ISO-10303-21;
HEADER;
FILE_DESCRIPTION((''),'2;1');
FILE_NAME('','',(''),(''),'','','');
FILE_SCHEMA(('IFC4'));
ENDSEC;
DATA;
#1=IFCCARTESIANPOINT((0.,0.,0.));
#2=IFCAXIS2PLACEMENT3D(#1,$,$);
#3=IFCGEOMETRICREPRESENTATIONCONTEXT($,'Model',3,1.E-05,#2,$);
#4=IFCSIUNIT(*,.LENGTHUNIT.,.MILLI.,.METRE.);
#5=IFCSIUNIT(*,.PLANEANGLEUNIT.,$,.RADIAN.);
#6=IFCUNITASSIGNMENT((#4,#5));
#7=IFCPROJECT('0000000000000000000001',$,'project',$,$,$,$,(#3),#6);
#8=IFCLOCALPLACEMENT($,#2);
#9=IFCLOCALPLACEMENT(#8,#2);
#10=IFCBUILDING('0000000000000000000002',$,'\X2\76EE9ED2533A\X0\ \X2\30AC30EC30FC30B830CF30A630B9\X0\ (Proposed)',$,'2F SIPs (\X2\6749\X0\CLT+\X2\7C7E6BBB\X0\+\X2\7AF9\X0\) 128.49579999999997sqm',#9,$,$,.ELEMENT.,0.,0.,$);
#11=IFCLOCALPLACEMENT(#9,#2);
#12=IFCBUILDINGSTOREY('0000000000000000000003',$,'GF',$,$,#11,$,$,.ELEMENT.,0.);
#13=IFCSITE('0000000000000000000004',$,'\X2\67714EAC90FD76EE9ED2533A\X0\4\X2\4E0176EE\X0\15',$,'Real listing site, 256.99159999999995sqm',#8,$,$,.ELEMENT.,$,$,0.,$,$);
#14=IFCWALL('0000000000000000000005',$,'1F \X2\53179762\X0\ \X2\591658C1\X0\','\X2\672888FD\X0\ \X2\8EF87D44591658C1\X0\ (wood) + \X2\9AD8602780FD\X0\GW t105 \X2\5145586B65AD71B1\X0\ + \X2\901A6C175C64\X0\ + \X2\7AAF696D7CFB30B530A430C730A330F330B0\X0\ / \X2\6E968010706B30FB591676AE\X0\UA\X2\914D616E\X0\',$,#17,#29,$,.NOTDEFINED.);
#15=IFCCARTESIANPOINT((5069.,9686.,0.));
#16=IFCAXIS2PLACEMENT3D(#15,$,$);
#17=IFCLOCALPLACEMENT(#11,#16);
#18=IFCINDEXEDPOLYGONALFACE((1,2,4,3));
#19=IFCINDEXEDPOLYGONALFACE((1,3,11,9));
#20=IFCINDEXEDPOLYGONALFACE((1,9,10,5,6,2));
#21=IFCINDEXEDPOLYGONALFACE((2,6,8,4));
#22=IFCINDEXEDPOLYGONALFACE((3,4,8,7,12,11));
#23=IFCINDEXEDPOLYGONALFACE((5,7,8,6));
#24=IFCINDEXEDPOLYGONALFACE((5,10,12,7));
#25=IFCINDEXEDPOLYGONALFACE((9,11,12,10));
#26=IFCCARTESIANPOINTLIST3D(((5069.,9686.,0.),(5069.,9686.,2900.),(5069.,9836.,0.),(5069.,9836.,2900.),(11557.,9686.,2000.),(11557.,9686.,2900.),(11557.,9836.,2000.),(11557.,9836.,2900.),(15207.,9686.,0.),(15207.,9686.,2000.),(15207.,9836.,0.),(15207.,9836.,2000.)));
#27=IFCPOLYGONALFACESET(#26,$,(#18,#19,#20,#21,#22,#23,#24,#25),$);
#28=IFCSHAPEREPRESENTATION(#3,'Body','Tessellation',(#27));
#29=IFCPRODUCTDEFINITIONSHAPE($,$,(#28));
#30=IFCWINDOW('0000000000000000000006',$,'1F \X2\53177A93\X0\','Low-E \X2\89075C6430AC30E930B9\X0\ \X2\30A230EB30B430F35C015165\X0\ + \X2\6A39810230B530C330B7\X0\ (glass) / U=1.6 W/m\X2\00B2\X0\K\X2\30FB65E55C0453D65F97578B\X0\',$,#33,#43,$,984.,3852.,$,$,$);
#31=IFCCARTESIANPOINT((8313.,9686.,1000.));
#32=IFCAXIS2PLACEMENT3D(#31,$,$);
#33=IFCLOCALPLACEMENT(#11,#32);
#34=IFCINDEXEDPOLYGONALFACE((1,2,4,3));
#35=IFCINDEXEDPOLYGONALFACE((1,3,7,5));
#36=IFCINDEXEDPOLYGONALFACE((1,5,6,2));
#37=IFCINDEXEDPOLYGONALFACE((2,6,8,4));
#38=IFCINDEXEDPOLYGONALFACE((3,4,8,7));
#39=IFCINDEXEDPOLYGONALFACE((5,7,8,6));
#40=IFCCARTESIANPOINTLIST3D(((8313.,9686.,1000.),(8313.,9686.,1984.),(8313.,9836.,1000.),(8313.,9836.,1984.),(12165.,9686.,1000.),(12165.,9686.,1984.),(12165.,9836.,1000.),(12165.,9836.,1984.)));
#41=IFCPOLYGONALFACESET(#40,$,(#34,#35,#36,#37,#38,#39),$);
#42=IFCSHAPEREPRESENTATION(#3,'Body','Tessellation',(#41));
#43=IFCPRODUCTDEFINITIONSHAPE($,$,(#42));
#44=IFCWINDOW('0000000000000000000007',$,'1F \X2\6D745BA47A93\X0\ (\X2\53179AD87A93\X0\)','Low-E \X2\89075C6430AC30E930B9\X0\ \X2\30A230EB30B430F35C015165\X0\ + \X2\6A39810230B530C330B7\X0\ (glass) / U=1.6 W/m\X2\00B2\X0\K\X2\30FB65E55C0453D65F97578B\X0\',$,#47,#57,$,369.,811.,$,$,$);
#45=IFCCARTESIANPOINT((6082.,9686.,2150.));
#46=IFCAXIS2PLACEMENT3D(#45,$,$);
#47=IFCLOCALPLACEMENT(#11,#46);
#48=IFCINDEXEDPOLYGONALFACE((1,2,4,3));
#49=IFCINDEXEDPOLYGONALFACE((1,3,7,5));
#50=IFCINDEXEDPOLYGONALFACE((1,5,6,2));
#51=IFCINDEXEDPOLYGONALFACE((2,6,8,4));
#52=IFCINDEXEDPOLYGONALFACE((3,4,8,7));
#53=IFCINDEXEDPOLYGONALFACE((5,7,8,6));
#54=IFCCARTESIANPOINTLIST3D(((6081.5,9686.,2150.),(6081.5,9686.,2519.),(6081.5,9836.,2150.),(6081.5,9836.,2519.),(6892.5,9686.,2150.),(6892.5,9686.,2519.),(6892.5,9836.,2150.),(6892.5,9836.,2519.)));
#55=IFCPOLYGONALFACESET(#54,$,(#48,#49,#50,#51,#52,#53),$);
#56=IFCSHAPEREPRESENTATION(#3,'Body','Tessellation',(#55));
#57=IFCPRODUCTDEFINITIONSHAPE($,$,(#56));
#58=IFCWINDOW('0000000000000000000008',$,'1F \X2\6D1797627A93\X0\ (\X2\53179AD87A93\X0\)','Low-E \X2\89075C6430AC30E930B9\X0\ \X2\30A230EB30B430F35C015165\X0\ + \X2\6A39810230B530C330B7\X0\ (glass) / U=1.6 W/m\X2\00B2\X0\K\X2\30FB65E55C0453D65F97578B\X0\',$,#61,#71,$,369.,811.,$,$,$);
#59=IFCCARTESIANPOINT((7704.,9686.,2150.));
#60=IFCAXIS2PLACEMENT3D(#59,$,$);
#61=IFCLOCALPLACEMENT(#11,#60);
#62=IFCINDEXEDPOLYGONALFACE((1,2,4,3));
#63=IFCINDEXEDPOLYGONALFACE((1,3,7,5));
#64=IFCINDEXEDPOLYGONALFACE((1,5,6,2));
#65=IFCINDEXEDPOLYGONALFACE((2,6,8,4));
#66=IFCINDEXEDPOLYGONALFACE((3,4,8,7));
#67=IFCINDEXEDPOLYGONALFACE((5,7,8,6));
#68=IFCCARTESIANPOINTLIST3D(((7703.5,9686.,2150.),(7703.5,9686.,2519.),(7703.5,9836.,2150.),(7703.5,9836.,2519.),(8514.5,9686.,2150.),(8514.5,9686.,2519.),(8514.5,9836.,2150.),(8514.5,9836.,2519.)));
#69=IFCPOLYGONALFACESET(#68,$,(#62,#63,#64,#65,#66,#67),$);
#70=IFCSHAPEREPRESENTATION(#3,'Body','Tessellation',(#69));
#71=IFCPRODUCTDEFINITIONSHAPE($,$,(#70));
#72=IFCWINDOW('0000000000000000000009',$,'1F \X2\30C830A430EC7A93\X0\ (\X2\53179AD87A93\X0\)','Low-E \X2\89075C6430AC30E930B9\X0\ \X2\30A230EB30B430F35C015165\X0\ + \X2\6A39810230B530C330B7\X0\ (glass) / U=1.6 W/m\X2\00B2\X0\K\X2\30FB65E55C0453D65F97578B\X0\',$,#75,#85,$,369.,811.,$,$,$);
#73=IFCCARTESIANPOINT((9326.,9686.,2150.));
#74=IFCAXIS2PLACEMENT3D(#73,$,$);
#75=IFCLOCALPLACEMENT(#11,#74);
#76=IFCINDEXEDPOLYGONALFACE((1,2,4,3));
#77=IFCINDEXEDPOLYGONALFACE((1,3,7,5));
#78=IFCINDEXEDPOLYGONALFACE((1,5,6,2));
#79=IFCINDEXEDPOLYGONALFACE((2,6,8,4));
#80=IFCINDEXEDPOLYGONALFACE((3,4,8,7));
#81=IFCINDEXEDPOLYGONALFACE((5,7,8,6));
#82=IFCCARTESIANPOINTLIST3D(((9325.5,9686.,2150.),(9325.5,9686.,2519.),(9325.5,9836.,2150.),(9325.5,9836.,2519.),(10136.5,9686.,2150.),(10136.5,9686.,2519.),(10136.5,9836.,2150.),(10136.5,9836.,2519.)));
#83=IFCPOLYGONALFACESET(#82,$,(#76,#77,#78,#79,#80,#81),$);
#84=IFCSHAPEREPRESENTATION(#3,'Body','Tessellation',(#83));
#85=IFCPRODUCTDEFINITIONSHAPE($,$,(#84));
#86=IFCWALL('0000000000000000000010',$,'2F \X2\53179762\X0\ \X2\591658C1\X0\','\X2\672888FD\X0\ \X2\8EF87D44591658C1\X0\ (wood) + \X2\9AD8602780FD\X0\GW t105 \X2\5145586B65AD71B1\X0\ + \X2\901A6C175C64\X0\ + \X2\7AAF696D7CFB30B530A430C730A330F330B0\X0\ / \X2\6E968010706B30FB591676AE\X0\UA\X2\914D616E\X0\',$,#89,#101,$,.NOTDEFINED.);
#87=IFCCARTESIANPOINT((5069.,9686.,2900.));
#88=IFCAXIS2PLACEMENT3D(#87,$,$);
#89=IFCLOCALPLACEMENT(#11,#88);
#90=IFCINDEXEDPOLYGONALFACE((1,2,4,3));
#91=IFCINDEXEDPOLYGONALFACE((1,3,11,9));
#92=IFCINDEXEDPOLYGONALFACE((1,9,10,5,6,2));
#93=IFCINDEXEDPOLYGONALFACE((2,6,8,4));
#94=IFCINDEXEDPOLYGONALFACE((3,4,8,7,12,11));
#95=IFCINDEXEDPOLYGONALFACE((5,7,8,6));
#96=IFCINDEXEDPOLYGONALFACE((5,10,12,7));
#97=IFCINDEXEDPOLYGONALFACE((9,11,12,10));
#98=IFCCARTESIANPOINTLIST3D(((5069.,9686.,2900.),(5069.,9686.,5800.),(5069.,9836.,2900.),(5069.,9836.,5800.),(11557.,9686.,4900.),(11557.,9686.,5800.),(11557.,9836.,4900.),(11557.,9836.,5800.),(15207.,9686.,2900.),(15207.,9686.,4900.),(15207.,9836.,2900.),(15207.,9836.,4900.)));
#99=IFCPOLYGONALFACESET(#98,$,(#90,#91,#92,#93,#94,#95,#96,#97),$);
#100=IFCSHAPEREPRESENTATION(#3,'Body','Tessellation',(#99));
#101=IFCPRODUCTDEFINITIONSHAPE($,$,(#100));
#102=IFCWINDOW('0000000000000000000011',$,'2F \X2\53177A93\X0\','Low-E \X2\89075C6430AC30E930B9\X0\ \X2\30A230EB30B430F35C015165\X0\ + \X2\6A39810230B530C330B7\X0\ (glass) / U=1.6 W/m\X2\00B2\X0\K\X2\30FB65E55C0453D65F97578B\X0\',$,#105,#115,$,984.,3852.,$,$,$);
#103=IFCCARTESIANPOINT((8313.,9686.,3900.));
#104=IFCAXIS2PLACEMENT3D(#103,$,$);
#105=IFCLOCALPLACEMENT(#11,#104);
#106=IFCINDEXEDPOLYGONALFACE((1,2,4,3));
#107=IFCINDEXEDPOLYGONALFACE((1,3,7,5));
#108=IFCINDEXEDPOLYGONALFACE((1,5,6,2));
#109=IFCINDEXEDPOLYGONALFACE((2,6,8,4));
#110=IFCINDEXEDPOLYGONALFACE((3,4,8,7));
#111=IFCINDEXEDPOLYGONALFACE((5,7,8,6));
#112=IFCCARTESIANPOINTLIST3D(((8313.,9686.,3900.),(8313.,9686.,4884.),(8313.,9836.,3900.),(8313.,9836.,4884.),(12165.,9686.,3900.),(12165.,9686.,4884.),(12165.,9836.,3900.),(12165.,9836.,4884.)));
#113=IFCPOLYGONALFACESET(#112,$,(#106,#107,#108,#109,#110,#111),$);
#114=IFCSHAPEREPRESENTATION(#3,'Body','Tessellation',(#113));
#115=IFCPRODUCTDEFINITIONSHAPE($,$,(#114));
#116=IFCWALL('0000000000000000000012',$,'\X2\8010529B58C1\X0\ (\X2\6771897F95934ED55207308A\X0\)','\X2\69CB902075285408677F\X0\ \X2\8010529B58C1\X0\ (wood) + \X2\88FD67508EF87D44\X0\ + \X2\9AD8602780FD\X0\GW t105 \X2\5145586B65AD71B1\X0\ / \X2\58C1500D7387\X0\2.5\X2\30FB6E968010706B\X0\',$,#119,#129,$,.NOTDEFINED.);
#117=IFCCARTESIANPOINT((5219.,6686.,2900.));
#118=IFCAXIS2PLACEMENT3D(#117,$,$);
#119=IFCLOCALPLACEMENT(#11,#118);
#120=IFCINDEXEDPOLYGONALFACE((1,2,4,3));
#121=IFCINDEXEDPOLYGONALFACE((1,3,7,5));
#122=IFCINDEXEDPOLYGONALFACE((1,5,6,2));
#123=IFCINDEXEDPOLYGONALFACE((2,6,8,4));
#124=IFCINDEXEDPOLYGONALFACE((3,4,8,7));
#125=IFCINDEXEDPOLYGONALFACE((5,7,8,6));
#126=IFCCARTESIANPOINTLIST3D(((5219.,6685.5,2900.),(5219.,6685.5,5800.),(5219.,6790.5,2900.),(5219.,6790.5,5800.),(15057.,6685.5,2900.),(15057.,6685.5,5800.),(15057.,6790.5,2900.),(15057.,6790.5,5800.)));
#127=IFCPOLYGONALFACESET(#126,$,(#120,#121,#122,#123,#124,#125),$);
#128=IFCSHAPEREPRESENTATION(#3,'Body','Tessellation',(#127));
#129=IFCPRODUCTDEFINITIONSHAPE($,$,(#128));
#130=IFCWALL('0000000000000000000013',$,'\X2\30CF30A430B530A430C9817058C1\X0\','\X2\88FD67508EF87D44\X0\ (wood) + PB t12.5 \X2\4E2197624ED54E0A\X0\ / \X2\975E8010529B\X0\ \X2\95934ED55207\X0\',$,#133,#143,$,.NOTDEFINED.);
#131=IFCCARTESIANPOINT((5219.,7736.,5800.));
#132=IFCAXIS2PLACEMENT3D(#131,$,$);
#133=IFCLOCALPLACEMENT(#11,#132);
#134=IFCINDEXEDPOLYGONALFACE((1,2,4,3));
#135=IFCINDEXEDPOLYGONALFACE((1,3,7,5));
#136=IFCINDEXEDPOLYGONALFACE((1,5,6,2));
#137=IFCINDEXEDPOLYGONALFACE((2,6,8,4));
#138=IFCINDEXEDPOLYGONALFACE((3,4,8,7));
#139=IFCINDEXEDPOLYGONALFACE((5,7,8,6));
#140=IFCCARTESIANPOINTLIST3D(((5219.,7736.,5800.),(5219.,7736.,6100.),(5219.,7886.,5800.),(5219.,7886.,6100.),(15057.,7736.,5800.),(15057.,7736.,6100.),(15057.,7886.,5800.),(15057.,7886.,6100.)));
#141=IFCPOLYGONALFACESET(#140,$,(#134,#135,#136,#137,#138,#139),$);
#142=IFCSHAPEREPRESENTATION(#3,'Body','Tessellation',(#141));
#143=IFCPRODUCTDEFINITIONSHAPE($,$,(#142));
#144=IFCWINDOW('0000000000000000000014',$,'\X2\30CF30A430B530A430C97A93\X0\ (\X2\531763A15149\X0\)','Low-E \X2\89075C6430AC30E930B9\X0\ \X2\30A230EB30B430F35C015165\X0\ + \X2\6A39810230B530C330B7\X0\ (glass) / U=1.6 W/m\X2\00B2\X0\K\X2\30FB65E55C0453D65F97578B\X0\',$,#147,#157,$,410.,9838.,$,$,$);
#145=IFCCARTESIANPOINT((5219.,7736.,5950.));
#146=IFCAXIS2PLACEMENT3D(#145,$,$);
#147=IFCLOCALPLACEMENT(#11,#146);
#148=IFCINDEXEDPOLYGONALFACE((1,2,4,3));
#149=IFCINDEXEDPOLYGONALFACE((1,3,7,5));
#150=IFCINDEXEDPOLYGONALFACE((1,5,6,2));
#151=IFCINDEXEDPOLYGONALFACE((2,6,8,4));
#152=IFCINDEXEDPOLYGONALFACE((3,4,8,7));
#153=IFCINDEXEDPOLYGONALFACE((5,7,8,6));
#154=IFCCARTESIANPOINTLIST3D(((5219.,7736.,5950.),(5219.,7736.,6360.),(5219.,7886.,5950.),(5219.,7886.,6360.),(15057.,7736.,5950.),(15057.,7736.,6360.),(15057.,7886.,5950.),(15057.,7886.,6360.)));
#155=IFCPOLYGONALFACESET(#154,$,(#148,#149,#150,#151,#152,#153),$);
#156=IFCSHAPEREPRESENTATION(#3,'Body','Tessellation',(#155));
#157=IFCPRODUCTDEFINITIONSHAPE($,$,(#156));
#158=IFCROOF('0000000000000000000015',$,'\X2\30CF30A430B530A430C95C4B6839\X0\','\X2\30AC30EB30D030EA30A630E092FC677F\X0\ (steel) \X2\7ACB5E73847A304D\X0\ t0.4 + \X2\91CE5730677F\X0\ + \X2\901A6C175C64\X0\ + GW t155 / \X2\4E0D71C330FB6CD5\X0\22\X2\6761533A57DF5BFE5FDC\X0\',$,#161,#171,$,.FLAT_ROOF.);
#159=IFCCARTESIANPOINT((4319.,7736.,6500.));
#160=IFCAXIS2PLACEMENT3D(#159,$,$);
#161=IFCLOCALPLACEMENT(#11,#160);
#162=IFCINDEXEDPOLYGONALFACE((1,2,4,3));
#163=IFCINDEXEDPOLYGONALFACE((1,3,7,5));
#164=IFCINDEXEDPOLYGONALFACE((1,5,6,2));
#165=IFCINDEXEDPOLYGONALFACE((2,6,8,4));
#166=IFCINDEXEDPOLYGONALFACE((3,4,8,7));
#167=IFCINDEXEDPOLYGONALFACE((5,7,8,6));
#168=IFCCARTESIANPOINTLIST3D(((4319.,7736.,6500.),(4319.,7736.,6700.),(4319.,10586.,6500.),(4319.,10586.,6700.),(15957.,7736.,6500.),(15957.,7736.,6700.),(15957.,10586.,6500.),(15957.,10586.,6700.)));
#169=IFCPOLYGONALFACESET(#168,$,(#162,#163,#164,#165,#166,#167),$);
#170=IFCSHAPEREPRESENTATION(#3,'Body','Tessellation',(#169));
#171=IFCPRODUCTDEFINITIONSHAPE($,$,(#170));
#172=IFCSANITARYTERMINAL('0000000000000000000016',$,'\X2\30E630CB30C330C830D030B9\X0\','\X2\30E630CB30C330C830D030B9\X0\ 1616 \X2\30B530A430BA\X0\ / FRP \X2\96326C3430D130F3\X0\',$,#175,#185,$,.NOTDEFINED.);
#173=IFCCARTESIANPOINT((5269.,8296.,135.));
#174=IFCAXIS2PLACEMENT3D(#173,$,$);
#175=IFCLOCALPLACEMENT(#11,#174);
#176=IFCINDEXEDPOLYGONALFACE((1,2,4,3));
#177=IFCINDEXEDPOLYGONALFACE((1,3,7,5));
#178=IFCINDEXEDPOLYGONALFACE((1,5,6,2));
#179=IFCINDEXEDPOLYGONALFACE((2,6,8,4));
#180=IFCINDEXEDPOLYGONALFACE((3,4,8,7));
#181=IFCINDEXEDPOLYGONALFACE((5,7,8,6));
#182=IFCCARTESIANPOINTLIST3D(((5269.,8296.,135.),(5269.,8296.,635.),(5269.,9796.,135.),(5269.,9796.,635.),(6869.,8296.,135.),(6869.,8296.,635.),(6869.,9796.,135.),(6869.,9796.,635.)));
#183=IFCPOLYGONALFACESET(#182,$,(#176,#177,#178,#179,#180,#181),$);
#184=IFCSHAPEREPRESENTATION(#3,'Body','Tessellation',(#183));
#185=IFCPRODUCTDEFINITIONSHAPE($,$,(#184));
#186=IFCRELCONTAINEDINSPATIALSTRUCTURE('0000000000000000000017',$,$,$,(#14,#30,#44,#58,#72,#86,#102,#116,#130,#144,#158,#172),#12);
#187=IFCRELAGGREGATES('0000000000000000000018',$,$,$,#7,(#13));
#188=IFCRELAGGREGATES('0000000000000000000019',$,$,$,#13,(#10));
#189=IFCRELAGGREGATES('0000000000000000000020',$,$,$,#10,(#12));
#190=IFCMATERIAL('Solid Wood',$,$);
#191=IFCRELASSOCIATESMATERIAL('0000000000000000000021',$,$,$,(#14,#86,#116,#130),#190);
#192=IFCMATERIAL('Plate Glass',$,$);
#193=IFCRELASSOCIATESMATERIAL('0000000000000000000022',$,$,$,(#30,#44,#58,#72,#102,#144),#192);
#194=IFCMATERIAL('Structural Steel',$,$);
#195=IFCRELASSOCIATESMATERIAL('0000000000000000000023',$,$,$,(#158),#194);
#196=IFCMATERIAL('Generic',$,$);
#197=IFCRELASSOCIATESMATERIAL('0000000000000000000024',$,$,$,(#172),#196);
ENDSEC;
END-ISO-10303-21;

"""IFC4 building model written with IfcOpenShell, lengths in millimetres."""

from ifc_helpers import new_model, si_unit, frame, frame_2d, origin, place, context, project, spatial, rectangle, extrude, material, element, fill, save


model = new_model("IFC4")

# Units and contexts
model_context = context("Model", 3, precision=1e-05, world=origin())
ifc_project = project(units=[si_unit("LENGTHUNIT", "METRE", prefix="MILLI"), si_unit("PLANEANGLEUNIT", "RADIAN")], contexts=[model_context])

# Site, building, storey
site_placement = place(None, origin())
site = spatial("IfcSite", under=ifc_project, at=site_placement, Name="東京都目黒区4丁目15", ObjectType="Real listing site, 256.99159999999995sqm", CompositionType="ELEMENT", RefElevation=0.0)
building_placement = place(site_placement, origin())
building = spatial("IfcBuilding", under=site, at=building_placement, Name="目黒区 ガレージハウス (Proposed)", ObjectType="2F SIPs (杉CLT+籾殻+竹) 128.49579999999997sqm", CompositionType="ELEMENT", ElevationOfRefHeight=0.0, ElevationOfTerrain=0.0)
storey_placement = place(building_placement, origin())
storey = spatial("IfcBuildingStorey", under=building, at=storey_placement, Name="GF", CompositionType="ELEMENT", Elevation=0.0)

# Wall, openings, windows
ifc_material_1 = material(Name="Solid Wood")
wall_1_placement = place(storey_placement, frame((5069.0, 9686.0, 0.0)))
wall_1 = element("IfcWall", 1, at=wall_1_placement, inside=storey, material=ifc_material_1, Name="1F 北面 外壁", Description="木製 軸組外壁 (wood) + 高性能GW t105 充填断熱 + 通気層 + 窯業系サイディング / 準耐火・外皮UA配慮", PredefinedType="NOTDEFINED", context=model_context, shape_type="SweptSolid", body=[
    extrude(rectangle(XDim=10138.0, YDim=150.0, at=frame_2d((5069.0, 75.0))), frame((5069.0, 9686.0, 0.0)), (0.0, 0.0, 1.0), 2900.0),
])
opening_1_placement = place(storey_placement, frame((8313.0, 9686.0, 1000.0)))
opening_1 = element("IfcOpeningElement", 2, at=opening_1_placement, cuts=wall_1, PredefinedType="NOTDEFINED", context=model_context, shape_type="SweptSolid", body=[
    extrude(rectangle(XDim=3852.0, YDim=150.0, at=frame_2d((1926.0, 75.0))), frame((8313.0, 9686.0, 1000.0)), (0.0, 0.0, 1.0), 984.0),
])
opening_2_placement = place(storey_placement, frame((6082.0, 9686.0, 2150.0)))
opening_2 = element("IfcOpeningElement", 3, at=opening_2_placement, cuts=wall_1, PredefinedType="NOTDEFINED", context=model_context, shape_type="SweptSolid", body=[
    extrude(rectangle(XDim=811.0, YDim=150.0, at=frame_2d((405.0, 75.0))), frame((6082.0, 9686.0, 2150.0)), (0.0, 0.0, 1.0), 369.0),
])
opening_3_placement = place(storey_placement, frame((7704.0, 9686.0, 2150.0)))
opening_3 = element("IfcOpeningElement", 4, at=opening_3_placement, cuts=wall_1, PredefinedType="NOTDEFINED", context=model_context, shape_type="SweptSolid", body=[
    extrude(rectangle(XDim=811.0, YDim=150.0, at=frame_2d((405.0, 75.0))), frame((7704.0, 9686.0, 2150.0)), (0.0, 0.0, 1.0), 369.0),
])
opening_4_placement = place(storey_placement, frame((9326.0, 9686.0, 2150.0)))
opening_4 = element("IfcOpeningElement", 5, at=opening_4_placement, cuts=wall_1, PredefinedType="NOTDEFINED", context=model_context, shape_type="SweptSolid", body=[
    extrude(rectangle(XDim=811.0, YDim=150.0, at=frame_2d((405.0, 75.0))), frame((9326.0, 9686.0, 2150.0)), (0.0, 0.0, 1.0), 369.0),
])
ifc_material_2 = material(Name="Plate Glass")
window_1_placement = place(storey_placement, frame((8313.0, 9686.0, 1000.0)))
window_1 = element("IfcWindow", 6, at=window_1_placement, inside=storey, material=ifc_material_2, Name="1F 北窓", Description="Low-E 複層ガラス アルゴン封入 + 樹脂サッシ (glass) / U=1.6 W/m²K・日射取得型", OverallHeight=984.0, OverallWidth=3852.0, context=model_context, shape_type="SweptSolid", body=[
    extrude(rectangle(XDim=3852.0, YDim=150.0, at=frame_2d((1926.0, 75.0))), frame((8313.0, 9686.0, 1000.0)), (0.0, 0.0, 1.0), 984.0),
])
fill(opening_1, window_1)
window_2_placement = place(storey_placement, frame((6082.0, 9686.0, 2150.0)))
window_2 = element("IfcWindow", 7, at=window_2_placement, inside=storey, material=ifc_material_2, Name="1F 浴室窓 (北高窓)", Description="Low-E 複層ガラス アルゴン封入 + 樹脂サッシ (glass) / U=1.6 W/m²K・日射取得型", OverallHeight=369.0, OverallWidth=811.0, context=model_context, shape_type="SweptSolid", body=[
    extrude(rectangle(XDim=811.0, YDim=150.0, at=frame_2d((405.0, 75.0))), frame((6082.0, 9686.0, 2150.0)), (0.0, 0.0, 1.0), 369.0),
])
fill(opening_2, window_2)
window_3_placement = place(storey_placement, frame((7704.0, 9686.0, 2150.0)))
window_3 = element("IfcWindow", 8, at=window_3_placement, inside=storey, material=ifc_material_2, Name="1F 洗面窓 (北高窓)", Description="Low-E 複層ガラス アルゴン封入 + 樹脂サッシ (glass) / U=1.6 W/m²K・日射取得型", OverallHeight=369.0, OverallWidth=811.0, context=model_context, shape_type="SweptSolid", body=[
    extrude(rectangle(XDim=811.0, YDim=150.0, at=frame_2d((405.0, 75.0))), frame((7704.0, 9686.0, 2150.0)), (0.0, 0.0, 1.0), 369.0),
])
fill(opening_3, window_3)
window_4_placement = place(storey_placement, frame((9326.0, 9686.0, 2150.0)))
window_4 = element("IfcWindow", 9, at=window_4_placement, inside=storey, material=ifc_material_2, Name="1F トイレ窓 (北高窓)", Description="Low-E 複層ガラス アルゴン封入 + 樹脂サッシ (glass) / U=1.6 W/m²K・日射取得型", OverallHeight=369.0, OverallWidth=811.0, context=model_context, shape_type="SweptSolid", body=[
    extrude(rectangle(XDim=811.0, YDim=150.0, at=frame_2d((405.0, 75.0))), frame((9326.0, 9686.0, 2150.0)), (0.0, 0.0, 1.0), 369.0),
])
fill(opening_4, window_4)

# Wall, opening, window
wall_2_placement = place(storey_placement, frame((5069.0, 9686.0, 2900.0)))
wall_2 = element("IfcWall", 10, at=wall_2_placement, inside=storey, material=ifc_material_1, Name="2F 北面 外壁", Description="木製 軸組外壁 (wood) + 高性能GW t105 充填断熱 + 通気層 + 窯業系サイディング / 準耐火・外皮UA配慮", PredefinedType="NOTDEFINED", context=model_context, shape_type="SweptSolid", body=[
    extrude(rectangle(XDim=10138.0, YDim=150.0, at=frame_2d((5069.0, 75.0))), frame((5069.0, 9686.0, 2900.0)), (0.0, 0.0, 1.0), 2900.0),
])
opening_5_placement = place(storey_placement, frame((8313.0, 9686.0, 3900.0)))
opening_5 = element("IfcOpeningElement", 11, at=opening_5_placement, cuts=wall_2, PredefinedType="NOTDEFINED", context=model_context, shape_type="SweptSolid", body=[
    extrude(rectangle(XDim=3852.0, YDim=150.0, at=frame_2d((1926.0, 75.0))), frame((8313.0, 9686.0, 3900.0)), (0.0, 0.0, 1.0), 984.0),
])
window_5_placement = place(storey_placement, frame((8313.0, 9686.0, 3900.0)))
window_5 = element("IfcWindow", 12, at=window_5_placement, inside=storey, material=ifc_material_2, Name="2F 北窓", Description="Low-E 複層ガラス アルゴン封入 + 樹脂サッシ (glass) / U=1.6 W/m²K・日射取得型", OverallHeight=984.0, OverallWidth=3852.0, context=model_context, shape_type="SweptSolid", body=[
    extrude(rectangle(XDim=3852.0, YDim=150.0, at=frame_2d((1926.0, 75.0))), frame((8313.0, 9686.0, 3900.0)), (0.0, 0.0, 1.0), 984.0),
])
fill(opening_5, window_5)

# Wall
wall_3_placement = place(storey_placement, frame((5219.0, 6686.0, 2900.0)))
element("IfcWall", 13, at=wall_3_placement, inside=storey, material=ifc_material_1, Name="耐力壁 (東西間仕切り)", Description="構造用合板 耐力壁 (wood) + 製材軸組 + 高性能GW t105 充填断熱 / 壁倍率2.5・準耐火", PredefinedType="NOTDEFINED", context=model_context, shape_type="SweptSolid", body=[
    extrude(rectangle(XDim=9838.0, YDim=105.0, at=frame_2d((4919.0, 52.0))), frame((5219.0, 6686.0, 2900.0)), (0.0, 0.0, 1.0), 2900.0),
])

# Wall, opening, window
wall_4_placement = place(storey_placement, frame((5219.0, 7736.0, 5800.0)))
wall_4 = element("IfcWall", 14, at=wall_4_placement, inside=storey, material=ifc_material_1, Name="ハイサイド腰壁", Description="製材軸組 (wood) + PB t12.5 両面仕上 / 非耐力 間仕切", PredefinedType="NOTDEFINED", context=model_context, shape_type="SweptSolid", body=[
    extrude(rectangle(XDim=9838.0, YDim=150.0, at=frame_2d((4919.0, 75.0))), frame((5219.0, 7736.0, 5800.0)), (0.0, 0.0, 1.0), 700.0),
])
opening_6_placement = place(storey_placement, frame((5219.0, 7736.0, 5950.0)))
opening_6 = element("IfcOpeningElement", 15, at=opening_6_placement, cuts=wall_4, PredefinedType="NOTDEFINED", context=model_context, shape_type="SweptSolid", body=[
    extrude(rectangle(XDim=9838.0, YDim=150.0, at=frame_2d((4919.0, 75.0))), frame((5219.0, 7736.0, 5950.0)), (0.0, 0.0, 1.0), 410.0),
])
window_6_placement = place(storey_placement, frame((5219.0, 7736.0, 5950.0)))
window_6 = element("IfcWindow", 16, at=window_6_placement, inside=storey, material=ifc_material_2, Name="ハイサイド窓 (北採光)", Description="Low-E 複層ガラス アルゴン封入 + 樹脂サッシ (glass) / U=1.6 W/m²K・日射取得型", OverallHeight=410.0, OverallWidth=9838.0, context=model_context, shape_type="SweptSolid", body=[
    extrude(rectangle(XDim=9838.0, YDim=150.0, at=frame_2d((4919.0, 75.0))), frame((5219.0, 7736.0, 5950.0)), (0.0, 0.0, 1.0), 410.0),
])
fill(opening_6, window_6)

# Roof
ifc_material_3 = material(Name="Structural Steel")
roof_placement = place(storey_placement, frame((4319.0, 7736.0, 6500.0)))
element("IfcRoof", 17, at=roof_placement, inside=storey, material=ifc_material_3, Name="ハイサイド屋根", Description="ガルバリウム鋼板 (steel) 立平葺き t0.4 + 野地板 + 通気層 + GW t155 / 不燃・法22条区域対応", PredefinedType="FLAT_ROOF", context=model_context, shape_type="SweptSolid", body=[
    extrude(rectangle(XDim=11638.0, YDim=2850.0, at=frame_2d((5819.0, 1425.0))), frame((4319.0, 7736.0, 6500.0)), (0.0, 0.0, 1.0), 200.0),
])

# Sanitary terminal
ifc_material_4 = material(Name="Generic")
sanitary_terminal_placement = place(storey_placement, frame((5269.0, 8296.0, 135.0)))
element("IfcSanitaryTerminal", 18, at=sanitary_terminal_placement, inside=storey, material=ifc_material_4, Name="ユニットバス", Description="ユニットバス 1616 サイズ / FRP 防水パン", PredefinedType="NOTDEFINED", context=model_context, shape_type="SweptSolid", body=[
    extrude(rectangle(XDim=1600.0, YDim=1500.0, at=frame_2d((800.0, 750.0))), frame((5269.0, 8296.0, 135.0)), (0.0, 0.0, 1.0), 500.0),
])

save(model, "model.ifc")
